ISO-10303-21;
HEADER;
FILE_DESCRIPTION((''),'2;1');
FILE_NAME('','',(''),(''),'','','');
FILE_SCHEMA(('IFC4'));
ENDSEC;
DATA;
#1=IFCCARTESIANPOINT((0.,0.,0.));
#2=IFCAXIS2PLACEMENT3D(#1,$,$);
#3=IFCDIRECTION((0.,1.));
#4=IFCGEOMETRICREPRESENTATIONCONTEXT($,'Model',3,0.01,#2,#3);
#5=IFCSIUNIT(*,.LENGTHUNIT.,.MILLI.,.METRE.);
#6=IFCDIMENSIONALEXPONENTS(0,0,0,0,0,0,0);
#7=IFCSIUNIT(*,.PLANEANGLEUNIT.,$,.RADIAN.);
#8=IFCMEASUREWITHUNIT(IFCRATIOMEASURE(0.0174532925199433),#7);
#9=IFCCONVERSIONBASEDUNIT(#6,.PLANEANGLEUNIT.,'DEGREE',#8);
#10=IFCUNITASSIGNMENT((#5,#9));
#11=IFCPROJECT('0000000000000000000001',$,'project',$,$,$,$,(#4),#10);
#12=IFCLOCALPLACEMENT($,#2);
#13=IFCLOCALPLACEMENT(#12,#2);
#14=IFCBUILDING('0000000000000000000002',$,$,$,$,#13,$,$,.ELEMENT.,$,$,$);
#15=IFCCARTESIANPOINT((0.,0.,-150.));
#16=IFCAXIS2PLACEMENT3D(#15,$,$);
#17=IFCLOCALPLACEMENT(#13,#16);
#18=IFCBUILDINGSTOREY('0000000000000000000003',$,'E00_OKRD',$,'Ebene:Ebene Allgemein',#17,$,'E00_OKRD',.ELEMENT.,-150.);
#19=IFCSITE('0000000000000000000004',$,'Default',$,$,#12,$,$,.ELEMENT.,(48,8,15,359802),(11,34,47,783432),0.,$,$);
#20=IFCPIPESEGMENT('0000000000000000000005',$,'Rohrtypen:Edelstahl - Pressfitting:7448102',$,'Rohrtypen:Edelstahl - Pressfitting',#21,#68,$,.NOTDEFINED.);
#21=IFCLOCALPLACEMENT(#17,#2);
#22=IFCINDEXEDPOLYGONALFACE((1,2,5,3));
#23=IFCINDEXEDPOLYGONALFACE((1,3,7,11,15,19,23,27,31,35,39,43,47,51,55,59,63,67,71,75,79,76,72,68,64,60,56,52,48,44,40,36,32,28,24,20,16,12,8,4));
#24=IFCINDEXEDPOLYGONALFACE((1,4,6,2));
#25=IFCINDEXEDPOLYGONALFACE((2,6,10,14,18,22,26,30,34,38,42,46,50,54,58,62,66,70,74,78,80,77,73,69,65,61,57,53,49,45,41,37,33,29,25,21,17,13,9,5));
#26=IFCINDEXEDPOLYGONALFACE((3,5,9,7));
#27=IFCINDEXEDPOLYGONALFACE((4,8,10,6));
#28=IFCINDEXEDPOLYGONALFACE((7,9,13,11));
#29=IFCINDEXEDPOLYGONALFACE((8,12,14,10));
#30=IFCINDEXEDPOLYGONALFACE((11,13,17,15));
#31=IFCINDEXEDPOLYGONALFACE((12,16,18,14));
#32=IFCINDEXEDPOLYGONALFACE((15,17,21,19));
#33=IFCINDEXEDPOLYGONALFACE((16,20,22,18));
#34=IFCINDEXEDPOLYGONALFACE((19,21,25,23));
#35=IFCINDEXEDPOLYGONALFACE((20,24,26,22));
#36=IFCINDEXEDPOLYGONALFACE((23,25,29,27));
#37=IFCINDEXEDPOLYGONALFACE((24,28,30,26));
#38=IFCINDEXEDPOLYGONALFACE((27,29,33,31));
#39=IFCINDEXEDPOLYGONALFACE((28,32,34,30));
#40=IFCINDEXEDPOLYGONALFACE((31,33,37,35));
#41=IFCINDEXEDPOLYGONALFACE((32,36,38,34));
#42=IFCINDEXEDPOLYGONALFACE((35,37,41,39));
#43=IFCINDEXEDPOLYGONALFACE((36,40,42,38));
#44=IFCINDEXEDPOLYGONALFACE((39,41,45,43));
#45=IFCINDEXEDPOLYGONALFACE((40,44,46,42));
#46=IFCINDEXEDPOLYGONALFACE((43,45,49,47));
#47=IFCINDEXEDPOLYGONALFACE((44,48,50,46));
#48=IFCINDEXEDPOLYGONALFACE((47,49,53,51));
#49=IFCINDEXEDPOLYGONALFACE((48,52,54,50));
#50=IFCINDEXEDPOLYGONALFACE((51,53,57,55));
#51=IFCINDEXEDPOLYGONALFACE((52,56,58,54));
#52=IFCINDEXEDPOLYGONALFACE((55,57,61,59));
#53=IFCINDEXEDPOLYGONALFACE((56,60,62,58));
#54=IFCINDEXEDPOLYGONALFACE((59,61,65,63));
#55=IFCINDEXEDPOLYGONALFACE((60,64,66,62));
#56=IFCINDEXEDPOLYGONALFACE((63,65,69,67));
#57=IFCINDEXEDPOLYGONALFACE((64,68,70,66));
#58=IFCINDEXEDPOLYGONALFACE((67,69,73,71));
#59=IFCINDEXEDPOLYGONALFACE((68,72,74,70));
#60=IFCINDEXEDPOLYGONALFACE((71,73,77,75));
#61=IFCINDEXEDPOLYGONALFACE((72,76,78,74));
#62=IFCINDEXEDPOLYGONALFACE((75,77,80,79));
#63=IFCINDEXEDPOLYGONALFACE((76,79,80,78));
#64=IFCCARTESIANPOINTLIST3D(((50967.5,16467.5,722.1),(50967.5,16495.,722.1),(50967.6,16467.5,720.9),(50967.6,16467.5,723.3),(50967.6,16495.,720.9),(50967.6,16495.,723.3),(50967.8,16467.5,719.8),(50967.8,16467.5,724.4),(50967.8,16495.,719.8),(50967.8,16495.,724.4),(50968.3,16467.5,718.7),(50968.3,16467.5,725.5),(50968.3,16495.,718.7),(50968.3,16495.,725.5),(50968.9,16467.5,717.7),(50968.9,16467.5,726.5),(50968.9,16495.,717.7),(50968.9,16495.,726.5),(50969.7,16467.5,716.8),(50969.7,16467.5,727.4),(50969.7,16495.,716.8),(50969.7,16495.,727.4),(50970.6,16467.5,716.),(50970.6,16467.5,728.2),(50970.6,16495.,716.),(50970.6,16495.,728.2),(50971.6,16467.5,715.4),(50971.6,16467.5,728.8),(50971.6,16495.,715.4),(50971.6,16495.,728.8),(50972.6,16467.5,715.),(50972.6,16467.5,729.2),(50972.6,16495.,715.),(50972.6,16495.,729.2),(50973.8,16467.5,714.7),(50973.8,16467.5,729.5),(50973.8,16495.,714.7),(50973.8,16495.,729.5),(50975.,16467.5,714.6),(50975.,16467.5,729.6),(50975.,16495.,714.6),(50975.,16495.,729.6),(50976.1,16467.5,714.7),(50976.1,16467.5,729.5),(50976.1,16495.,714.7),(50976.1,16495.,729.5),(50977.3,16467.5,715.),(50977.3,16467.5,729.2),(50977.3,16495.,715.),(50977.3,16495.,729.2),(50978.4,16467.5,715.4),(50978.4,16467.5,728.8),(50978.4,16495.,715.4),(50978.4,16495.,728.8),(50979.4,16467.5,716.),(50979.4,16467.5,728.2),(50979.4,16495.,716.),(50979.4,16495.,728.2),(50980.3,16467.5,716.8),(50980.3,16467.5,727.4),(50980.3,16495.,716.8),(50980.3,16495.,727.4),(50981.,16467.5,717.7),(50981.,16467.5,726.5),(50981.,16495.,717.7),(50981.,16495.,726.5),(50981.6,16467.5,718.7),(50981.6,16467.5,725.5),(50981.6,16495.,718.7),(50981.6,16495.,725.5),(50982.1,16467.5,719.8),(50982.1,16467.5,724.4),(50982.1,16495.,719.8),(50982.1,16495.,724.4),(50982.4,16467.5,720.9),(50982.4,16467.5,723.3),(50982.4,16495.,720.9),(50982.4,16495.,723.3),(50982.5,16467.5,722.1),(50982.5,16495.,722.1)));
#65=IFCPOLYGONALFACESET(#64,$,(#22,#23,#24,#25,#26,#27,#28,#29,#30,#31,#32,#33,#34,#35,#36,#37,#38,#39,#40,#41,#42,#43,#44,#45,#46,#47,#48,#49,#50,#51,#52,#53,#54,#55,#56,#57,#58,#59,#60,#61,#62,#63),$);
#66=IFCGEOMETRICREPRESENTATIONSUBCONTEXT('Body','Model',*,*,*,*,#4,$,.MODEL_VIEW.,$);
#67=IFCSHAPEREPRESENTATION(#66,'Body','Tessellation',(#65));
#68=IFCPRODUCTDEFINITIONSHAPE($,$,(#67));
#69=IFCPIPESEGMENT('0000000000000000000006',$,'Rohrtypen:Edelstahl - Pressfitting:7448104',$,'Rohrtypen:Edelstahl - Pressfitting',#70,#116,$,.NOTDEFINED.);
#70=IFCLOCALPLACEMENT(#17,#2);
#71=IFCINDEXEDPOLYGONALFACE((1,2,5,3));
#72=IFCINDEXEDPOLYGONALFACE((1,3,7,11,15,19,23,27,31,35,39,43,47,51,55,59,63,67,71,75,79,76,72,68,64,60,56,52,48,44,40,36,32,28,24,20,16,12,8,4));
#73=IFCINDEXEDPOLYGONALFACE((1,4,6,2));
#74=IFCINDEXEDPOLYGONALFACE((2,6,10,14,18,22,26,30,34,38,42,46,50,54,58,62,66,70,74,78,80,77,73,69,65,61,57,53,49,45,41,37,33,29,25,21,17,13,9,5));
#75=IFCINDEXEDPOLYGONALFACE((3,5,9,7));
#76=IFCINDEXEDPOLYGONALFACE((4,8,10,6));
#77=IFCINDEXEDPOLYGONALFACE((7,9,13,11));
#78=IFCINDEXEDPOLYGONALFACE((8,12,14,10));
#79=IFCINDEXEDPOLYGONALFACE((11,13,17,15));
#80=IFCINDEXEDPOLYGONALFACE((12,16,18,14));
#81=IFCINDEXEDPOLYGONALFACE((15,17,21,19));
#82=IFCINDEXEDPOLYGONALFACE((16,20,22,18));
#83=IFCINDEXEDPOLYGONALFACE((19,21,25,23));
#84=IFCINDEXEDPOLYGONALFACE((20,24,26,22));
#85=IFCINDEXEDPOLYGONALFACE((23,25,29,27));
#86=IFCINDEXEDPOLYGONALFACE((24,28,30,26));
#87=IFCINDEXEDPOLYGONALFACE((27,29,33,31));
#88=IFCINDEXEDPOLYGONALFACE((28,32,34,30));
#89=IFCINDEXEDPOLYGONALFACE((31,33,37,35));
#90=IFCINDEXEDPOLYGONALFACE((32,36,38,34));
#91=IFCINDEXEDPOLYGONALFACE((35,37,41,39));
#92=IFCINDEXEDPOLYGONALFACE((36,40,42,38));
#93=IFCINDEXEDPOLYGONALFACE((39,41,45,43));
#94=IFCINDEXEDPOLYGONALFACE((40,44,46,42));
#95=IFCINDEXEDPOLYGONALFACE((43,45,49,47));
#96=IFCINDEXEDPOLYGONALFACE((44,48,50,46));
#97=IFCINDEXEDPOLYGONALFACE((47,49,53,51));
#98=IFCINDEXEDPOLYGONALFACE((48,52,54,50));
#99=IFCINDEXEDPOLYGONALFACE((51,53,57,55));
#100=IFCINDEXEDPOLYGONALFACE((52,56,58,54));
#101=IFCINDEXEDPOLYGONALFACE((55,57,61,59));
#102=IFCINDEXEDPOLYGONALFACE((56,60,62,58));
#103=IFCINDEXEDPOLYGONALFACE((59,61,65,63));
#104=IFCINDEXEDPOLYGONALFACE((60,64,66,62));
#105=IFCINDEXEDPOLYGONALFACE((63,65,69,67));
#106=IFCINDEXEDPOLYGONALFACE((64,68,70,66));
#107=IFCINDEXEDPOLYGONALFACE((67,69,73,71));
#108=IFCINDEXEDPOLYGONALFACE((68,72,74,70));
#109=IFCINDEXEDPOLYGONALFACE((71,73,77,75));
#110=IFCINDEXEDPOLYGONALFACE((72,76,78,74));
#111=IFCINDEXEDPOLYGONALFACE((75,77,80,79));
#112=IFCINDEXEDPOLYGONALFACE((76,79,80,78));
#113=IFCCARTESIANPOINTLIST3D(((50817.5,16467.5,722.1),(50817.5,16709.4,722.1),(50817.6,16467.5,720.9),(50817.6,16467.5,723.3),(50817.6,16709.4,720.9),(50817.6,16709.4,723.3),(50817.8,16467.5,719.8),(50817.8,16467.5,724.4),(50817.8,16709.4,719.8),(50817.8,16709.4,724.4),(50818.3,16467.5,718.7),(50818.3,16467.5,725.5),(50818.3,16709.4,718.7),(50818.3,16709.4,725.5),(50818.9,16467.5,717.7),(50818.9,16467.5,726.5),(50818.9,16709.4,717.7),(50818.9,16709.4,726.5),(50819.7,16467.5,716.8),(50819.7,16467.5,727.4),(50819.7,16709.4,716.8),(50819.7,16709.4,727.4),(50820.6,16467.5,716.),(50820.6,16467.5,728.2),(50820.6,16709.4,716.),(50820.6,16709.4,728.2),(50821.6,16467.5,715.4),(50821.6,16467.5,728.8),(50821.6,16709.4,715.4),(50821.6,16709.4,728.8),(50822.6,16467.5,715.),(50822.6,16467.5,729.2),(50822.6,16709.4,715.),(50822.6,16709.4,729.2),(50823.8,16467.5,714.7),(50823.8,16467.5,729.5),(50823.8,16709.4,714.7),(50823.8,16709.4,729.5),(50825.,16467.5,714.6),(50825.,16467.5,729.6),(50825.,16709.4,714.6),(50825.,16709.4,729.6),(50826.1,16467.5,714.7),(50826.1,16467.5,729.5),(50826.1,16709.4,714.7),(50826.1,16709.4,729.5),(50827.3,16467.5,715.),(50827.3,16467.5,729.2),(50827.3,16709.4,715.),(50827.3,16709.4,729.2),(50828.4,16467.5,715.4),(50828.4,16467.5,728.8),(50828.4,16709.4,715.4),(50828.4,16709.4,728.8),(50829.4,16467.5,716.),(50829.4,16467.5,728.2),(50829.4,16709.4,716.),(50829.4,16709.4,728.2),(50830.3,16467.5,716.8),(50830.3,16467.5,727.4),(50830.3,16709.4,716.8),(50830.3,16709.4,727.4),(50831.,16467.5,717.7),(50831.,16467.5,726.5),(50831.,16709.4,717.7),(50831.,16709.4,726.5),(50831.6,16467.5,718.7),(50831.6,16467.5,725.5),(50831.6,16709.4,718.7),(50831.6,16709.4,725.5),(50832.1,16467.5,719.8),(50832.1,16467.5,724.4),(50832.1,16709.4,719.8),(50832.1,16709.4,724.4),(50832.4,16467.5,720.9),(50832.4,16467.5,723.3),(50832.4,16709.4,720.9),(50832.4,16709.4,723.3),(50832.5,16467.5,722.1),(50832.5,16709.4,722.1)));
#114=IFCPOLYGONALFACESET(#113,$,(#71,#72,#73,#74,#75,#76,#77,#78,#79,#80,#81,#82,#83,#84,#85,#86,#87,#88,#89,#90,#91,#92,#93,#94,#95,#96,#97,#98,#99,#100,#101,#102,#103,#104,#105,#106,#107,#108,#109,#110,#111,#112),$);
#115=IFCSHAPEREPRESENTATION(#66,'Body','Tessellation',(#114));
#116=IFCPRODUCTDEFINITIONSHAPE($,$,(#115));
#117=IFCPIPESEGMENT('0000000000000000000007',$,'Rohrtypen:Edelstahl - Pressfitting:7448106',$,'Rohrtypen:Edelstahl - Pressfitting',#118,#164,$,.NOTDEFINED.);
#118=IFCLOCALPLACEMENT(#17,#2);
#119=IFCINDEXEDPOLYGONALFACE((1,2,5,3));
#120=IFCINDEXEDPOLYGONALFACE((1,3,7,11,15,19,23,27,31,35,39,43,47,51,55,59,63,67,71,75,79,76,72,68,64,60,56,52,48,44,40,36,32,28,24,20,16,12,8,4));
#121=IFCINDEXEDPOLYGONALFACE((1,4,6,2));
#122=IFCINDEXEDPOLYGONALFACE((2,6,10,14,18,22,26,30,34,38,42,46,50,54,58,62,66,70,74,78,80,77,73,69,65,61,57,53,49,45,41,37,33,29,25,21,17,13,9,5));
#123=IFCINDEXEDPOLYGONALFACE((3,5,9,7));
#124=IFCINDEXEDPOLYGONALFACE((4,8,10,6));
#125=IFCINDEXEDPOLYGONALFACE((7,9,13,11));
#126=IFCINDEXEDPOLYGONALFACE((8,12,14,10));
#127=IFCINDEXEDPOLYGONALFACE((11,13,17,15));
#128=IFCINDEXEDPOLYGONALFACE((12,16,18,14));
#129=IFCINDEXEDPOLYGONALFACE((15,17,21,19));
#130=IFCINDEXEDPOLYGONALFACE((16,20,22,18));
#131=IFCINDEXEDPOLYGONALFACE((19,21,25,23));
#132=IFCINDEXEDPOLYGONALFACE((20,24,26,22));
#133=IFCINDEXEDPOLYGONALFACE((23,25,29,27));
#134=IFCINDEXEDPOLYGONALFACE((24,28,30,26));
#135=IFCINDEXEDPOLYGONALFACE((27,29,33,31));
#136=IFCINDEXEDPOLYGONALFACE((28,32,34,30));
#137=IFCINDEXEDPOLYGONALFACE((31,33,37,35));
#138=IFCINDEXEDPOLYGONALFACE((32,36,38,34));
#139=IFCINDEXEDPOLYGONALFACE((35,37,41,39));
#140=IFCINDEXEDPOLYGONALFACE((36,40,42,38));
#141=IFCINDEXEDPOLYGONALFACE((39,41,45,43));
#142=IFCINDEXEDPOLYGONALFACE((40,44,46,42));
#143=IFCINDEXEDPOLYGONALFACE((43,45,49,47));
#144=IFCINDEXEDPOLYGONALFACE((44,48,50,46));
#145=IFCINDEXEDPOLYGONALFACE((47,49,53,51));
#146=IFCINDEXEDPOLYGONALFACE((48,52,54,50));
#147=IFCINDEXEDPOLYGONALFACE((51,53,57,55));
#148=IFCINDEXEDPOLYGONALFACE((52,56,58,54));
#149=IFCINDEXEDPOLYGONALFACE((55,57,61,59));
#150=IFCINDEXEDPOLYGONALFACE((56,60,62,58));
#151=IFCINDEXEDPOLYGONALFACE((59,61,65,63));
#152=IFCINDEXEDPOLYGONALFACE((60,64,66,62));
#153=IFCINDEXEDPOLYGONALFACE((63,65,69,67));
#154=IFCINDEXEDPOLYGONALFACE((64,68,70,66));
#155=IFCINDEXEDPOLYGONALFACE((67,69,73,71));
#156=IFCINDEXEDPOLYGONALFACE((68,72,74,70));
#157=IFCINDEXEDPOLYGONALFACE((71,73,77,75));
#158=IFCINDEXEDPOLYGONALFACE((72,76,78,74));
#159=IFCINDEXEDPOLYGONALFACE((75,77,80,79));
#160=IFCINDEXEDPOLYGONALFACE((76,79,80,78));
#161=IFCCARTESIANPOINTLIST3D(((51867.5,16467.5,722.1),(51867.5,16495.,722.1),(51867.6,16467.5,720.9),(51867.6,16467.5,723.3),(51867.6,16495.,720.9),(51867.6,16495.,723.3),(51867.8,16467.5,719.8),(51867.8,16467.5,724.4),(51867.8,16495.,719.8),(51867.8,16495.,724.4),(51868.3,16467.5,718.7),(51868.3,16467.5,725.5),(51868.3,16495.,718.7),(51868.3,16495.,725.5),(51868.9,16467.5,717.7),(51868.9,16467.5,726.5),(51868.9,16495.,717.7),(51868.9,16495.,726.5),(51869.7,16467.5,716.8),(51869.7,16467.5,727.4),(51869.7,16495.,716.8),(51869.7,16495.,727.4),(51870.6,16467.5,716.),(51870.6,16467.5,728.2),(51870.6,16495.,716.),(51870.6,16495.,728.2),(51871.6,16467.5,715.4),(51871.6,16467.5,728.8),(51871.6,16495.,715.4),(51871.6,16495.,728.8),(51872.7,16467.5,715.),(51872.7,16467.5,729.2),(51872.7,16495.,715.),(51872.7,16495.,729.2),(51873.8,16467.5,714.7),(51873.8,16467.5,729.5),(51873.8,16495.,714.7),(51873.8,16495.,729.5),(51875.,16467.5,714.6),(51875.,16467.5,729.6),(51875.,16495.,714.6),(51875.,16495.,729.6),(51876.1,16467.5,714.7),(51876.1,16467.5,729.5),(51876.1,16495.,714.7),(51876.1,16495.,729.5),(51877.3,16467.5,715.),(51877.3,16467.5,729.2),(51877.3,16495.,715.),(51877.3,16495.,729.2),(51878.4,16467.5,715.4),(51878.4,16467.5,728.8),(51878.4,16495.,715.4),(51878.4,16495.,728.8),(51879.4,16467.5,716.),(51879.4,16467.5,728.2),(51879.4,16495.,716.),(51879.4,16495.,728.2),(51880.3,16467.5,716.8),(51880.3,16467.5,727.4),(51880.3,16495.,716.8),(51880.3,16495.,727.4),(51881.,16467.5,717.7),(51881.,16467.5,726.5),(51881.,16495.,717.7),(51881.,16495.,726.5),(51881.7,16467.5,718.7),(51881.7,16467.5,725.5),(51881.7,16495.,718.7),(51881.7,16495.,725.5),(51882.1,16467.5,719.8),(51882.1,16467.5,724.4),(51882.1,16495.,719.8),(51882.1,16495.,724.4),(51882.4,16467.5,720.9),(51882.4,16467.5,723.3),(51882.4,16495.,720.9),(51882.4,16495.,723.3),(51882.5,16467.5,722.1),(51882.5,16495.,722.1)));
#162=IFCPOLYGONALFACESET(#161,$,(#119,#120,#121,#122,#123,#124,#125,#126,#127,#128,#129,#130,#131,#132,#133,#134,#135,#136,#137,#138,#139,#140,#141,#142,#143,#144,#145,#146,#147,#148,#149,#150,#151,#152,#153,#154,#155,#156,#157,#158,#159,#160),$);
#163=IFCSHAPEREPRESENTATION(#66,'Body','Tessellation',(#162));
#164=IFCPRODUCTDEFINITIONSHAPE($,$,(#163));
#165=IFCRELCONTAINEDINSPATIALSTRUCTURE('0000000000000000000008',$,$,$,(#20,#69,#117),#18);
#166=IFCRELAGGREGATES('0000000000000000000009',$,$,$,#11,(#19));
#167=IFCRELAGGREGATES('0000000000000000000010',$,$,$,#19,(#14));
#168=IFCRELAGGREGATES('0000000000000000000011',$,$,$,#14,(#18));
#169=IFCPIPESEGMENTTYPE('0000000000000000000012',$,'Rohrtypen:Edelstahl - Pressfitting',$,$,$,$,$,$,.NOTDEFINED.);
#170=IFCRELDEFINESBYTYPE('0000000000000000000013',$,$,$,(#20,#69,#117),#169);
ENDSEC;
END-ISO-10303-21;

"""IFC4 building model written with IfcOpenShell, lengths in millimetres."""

from ifc_helpers import new_model, entity, si_unit, converted_unit, direction, frame, origin, place, context, subcontext, project, spatial, indexed_curve, outline, extrude, type_object, element, save


model = new_model("IFC4")

# Units and contexts
model_context = context("Model", 3, precision=0.01, world=origin(), true_north=direction((0.0, 1.0)))
body_context = subcontext(model_context, "Body", "Model", "MODEL_VIEW")
ifc_project = project(units=[si_unit("LENGTHUNIT", "METRE", prefix="MILLI"), converted_unit("PLANEANGLEUNIT", "DEGREE", entity("IfcRatioMeasure", 0.0174532925199433), si_unit("PLANEANGLEUNIT", "RADIAN"), dimensions=[0, 0, 0, 0, 0, 0, 0])], contexts=[model_context])

# Site, building, storey
site_placement = place(None, origin())
site = spatial("IfcSite", under=ifc_project, at=site_placement, Name="Default", CompositionType="ELEMENT", RefLatitude=(48, 8, 15, 359802), RefLongitude=(11, 34, 47, 783432), RefElevation=0.0)
building_placement = place(site_placement, origin())
building = spatial("IfcBuilding", under=site, at=building_placement, CompositionType="ELEMENT")
storey_placement = place(building_placement, frame((0.0, 0.0, -150.0)))
storey = spatial("IfcBuildingStorey", under=building, at=storey_placement, Name="E00_OKRD", ObjectType="Ebene:Ebene Allgemein", LongName="E00_OKRD", CompositionType="ELEMENT", Elevation=-150.0)

# Pipe segments
pipe_segment_type_1 = type_object("IfcPipeSegmentType", Name="Rohrtypen:Edelstahl - Pressfitting", PredefinedType="NOTDEFINED")
pipe_segment_1_placement = place(storey_placement, origin())
element("IfcPipeSegment", 1, at=pipe_segment_1_placement, inside=storey, type_object=pipe_segment_type_1, Name="Rohrtypen:Edelstahl - Pressfitting:7448102", ObjectType="Rohrtypen:Edelstahl - Pressfitting", PredefinedType="NOTDEFINED", context=body_context, shape_type="SweptSolid", body=[
    extrude(outline(indexed_curve([(7.5, 0.0), (7.4, 1.2), (7.1, 2.3), (6.7, 3.4), (6.1, 4.4), (5.3, 5.3), (4.4, 6.1), (3.4, 6.7), (2.3, 7.1), (1.2, 7.4), (0.0, 7.5), (-1.2, 7.4), (-2.3, 7.1), (-3.4, 6.7), (-4.4, 6.1), (-5.3, 5.3), (-6.1, 4.4), (-6.7, 3.4), (-7.1, 2.3), (-7.4, 1.2), (-7.5, 0.0), (-7.4, -1.2), (-7.1, -2.3), (-6.7, -3.4), (-6.1, -4.4), (-5.3, -5.3), (-4.4, -6.1), (-3.4, -6.7), (-2.3, -7.1), (-1.2, -7.4), (0.0, -7.5), (1.2, -7.4), (2.3, -7.1), (3.4, -6.7), (4.4, -6.1), (5.3, -5.3), (6.1, -4.4), (6.7, -3.4), (7.1, -2.3), (7.4, -1.2), (7.5, 0.0)], self_intersect=False)), frame((50975.0, 16467.5, 722.1), z_axis=(0.0, 1.0, 0.0), x_axis=(1.0, 0.0, 0.0)), (0.0, 0.0, 1.0), 27.4),
])
pipe_segment_2_placement = place(storey_placement, origin())
element("IfcPipeSegment", 2, at=pipe_segment_2_placement, inside=storey, type_object=pipe_segment_type_1, Name="Rohrtypen:Edelstahl - Pressfitting:7448104", ObjectType="Rohrtypen:Edelstahl - Pressfitting", PredefinedType="NOTDEFINED", context=body_context, shape_type="SweptSolid", body=[
    extrude(outline(indexed_curve([(7.5, 0.0), (7.4, 1.2), (7.1, 2.3), (6.7, 3.4), (6.1, 4.4), (5.3, 5.3), (4.4, 6.1), (3.4, 6.7), (2.3, 7.1), (1.2, 7.4), (0.0, 7.5), (-1.2, 7.4), (-2.3, 7.1), (-3.4, 6.7), (-4.4, 6.1), (-5.3, 5.3), (-6.1, 4.4), (-6.7, 3.4), (-7.1, 2.3), (-7.4, 1.2), (-7.5, 0.0), (-7.4, -1.2), (-7.1, -2.3), (-6.7, -3.4), (-6.1, -4.4), (-5.3, -5.3), (-4.4, -6.1), (-3.4, -6.7), (-2.3, -7.1), (-1.2, -7.4), (0.0, -7.5), (1.2, -7.4), (2.3, -7.1), (3.4, -6.7), (4.4, -6.1), (5.3, -5.3), (6.1, -4.4), (6.7, -3.4), (7.1, -2.3), (7.4, -1.2), (7.5, 0.0)], self_intersect=False)), frame((50825.0, 16467.5, 722.1), z_axis=(0.0, 1.0, 0.0), x_axis=(-1.0, 0.0, 0.0)), (0.0, 0.0, 1.0), 241.8),
])
pipe_segment_3_placement = place(storey_placement, origin())
element("IfcPipeSegment", 3, at=pipe_segment_3_placement, inside=storey, type_object=pipe_segment_type_1, Name="Rohrtypen:Edelstahl - Pressfitting:7448106", ObjectType="Rohrtypen:Edelstahl - Pressfitting", PredefinedType="NOTDEFINED", context=body_context, shape_type="SweptSolid", body=[
    extrude(outline(indexed_curve([(7.5, 0.0), (7.4, 1.2), (7.1, 2.3), (6.7, 3.4), (6.1, 4.4), (5.3, 5.3), (4.4, 6.1), (3.4, 6.7), (2.3, 7.1), (1.2, 7.4), (0.0, 7.5), (-1.2, 7.4), (-2.3, 7.1), (-3.4, 6.7), (-4.4, 6.1), (-5.3, 5.3), (-6.1, 4.4), (-6.7, 3.4), (-7.1, 2.3), (-7.4, 1.2), (-7.5, 0.0), (-7.4, -1.2), (-7.1, -2.3), (-6.7, -3.4), (-6.1, -4.4), (-5.3, -5.3), (-4.4, -6.1), (-3.4, -6.7), (-2.3, -7.1), (-1.2, -7.4), (0.0, -7.5), (1.2, -7.4), (2.3, -7.1), (3.4, -6.7), (4.4, -6.1), (5.3, -5.3), (6.1, -4.4), (6.7, -3.4), (7.1, -2.3), (7.4, -1.2), (7.5, 0.0)], self_intersect=False)), frame((51875.0, 16467.5, 722.1), z_axis=(0.0, 1.0, 0.0), x_axis=(1.0, 0.0, 0.0)), (0.0, 0.0, 1.0), 27.4),
])

save(model, "model.ifc")
